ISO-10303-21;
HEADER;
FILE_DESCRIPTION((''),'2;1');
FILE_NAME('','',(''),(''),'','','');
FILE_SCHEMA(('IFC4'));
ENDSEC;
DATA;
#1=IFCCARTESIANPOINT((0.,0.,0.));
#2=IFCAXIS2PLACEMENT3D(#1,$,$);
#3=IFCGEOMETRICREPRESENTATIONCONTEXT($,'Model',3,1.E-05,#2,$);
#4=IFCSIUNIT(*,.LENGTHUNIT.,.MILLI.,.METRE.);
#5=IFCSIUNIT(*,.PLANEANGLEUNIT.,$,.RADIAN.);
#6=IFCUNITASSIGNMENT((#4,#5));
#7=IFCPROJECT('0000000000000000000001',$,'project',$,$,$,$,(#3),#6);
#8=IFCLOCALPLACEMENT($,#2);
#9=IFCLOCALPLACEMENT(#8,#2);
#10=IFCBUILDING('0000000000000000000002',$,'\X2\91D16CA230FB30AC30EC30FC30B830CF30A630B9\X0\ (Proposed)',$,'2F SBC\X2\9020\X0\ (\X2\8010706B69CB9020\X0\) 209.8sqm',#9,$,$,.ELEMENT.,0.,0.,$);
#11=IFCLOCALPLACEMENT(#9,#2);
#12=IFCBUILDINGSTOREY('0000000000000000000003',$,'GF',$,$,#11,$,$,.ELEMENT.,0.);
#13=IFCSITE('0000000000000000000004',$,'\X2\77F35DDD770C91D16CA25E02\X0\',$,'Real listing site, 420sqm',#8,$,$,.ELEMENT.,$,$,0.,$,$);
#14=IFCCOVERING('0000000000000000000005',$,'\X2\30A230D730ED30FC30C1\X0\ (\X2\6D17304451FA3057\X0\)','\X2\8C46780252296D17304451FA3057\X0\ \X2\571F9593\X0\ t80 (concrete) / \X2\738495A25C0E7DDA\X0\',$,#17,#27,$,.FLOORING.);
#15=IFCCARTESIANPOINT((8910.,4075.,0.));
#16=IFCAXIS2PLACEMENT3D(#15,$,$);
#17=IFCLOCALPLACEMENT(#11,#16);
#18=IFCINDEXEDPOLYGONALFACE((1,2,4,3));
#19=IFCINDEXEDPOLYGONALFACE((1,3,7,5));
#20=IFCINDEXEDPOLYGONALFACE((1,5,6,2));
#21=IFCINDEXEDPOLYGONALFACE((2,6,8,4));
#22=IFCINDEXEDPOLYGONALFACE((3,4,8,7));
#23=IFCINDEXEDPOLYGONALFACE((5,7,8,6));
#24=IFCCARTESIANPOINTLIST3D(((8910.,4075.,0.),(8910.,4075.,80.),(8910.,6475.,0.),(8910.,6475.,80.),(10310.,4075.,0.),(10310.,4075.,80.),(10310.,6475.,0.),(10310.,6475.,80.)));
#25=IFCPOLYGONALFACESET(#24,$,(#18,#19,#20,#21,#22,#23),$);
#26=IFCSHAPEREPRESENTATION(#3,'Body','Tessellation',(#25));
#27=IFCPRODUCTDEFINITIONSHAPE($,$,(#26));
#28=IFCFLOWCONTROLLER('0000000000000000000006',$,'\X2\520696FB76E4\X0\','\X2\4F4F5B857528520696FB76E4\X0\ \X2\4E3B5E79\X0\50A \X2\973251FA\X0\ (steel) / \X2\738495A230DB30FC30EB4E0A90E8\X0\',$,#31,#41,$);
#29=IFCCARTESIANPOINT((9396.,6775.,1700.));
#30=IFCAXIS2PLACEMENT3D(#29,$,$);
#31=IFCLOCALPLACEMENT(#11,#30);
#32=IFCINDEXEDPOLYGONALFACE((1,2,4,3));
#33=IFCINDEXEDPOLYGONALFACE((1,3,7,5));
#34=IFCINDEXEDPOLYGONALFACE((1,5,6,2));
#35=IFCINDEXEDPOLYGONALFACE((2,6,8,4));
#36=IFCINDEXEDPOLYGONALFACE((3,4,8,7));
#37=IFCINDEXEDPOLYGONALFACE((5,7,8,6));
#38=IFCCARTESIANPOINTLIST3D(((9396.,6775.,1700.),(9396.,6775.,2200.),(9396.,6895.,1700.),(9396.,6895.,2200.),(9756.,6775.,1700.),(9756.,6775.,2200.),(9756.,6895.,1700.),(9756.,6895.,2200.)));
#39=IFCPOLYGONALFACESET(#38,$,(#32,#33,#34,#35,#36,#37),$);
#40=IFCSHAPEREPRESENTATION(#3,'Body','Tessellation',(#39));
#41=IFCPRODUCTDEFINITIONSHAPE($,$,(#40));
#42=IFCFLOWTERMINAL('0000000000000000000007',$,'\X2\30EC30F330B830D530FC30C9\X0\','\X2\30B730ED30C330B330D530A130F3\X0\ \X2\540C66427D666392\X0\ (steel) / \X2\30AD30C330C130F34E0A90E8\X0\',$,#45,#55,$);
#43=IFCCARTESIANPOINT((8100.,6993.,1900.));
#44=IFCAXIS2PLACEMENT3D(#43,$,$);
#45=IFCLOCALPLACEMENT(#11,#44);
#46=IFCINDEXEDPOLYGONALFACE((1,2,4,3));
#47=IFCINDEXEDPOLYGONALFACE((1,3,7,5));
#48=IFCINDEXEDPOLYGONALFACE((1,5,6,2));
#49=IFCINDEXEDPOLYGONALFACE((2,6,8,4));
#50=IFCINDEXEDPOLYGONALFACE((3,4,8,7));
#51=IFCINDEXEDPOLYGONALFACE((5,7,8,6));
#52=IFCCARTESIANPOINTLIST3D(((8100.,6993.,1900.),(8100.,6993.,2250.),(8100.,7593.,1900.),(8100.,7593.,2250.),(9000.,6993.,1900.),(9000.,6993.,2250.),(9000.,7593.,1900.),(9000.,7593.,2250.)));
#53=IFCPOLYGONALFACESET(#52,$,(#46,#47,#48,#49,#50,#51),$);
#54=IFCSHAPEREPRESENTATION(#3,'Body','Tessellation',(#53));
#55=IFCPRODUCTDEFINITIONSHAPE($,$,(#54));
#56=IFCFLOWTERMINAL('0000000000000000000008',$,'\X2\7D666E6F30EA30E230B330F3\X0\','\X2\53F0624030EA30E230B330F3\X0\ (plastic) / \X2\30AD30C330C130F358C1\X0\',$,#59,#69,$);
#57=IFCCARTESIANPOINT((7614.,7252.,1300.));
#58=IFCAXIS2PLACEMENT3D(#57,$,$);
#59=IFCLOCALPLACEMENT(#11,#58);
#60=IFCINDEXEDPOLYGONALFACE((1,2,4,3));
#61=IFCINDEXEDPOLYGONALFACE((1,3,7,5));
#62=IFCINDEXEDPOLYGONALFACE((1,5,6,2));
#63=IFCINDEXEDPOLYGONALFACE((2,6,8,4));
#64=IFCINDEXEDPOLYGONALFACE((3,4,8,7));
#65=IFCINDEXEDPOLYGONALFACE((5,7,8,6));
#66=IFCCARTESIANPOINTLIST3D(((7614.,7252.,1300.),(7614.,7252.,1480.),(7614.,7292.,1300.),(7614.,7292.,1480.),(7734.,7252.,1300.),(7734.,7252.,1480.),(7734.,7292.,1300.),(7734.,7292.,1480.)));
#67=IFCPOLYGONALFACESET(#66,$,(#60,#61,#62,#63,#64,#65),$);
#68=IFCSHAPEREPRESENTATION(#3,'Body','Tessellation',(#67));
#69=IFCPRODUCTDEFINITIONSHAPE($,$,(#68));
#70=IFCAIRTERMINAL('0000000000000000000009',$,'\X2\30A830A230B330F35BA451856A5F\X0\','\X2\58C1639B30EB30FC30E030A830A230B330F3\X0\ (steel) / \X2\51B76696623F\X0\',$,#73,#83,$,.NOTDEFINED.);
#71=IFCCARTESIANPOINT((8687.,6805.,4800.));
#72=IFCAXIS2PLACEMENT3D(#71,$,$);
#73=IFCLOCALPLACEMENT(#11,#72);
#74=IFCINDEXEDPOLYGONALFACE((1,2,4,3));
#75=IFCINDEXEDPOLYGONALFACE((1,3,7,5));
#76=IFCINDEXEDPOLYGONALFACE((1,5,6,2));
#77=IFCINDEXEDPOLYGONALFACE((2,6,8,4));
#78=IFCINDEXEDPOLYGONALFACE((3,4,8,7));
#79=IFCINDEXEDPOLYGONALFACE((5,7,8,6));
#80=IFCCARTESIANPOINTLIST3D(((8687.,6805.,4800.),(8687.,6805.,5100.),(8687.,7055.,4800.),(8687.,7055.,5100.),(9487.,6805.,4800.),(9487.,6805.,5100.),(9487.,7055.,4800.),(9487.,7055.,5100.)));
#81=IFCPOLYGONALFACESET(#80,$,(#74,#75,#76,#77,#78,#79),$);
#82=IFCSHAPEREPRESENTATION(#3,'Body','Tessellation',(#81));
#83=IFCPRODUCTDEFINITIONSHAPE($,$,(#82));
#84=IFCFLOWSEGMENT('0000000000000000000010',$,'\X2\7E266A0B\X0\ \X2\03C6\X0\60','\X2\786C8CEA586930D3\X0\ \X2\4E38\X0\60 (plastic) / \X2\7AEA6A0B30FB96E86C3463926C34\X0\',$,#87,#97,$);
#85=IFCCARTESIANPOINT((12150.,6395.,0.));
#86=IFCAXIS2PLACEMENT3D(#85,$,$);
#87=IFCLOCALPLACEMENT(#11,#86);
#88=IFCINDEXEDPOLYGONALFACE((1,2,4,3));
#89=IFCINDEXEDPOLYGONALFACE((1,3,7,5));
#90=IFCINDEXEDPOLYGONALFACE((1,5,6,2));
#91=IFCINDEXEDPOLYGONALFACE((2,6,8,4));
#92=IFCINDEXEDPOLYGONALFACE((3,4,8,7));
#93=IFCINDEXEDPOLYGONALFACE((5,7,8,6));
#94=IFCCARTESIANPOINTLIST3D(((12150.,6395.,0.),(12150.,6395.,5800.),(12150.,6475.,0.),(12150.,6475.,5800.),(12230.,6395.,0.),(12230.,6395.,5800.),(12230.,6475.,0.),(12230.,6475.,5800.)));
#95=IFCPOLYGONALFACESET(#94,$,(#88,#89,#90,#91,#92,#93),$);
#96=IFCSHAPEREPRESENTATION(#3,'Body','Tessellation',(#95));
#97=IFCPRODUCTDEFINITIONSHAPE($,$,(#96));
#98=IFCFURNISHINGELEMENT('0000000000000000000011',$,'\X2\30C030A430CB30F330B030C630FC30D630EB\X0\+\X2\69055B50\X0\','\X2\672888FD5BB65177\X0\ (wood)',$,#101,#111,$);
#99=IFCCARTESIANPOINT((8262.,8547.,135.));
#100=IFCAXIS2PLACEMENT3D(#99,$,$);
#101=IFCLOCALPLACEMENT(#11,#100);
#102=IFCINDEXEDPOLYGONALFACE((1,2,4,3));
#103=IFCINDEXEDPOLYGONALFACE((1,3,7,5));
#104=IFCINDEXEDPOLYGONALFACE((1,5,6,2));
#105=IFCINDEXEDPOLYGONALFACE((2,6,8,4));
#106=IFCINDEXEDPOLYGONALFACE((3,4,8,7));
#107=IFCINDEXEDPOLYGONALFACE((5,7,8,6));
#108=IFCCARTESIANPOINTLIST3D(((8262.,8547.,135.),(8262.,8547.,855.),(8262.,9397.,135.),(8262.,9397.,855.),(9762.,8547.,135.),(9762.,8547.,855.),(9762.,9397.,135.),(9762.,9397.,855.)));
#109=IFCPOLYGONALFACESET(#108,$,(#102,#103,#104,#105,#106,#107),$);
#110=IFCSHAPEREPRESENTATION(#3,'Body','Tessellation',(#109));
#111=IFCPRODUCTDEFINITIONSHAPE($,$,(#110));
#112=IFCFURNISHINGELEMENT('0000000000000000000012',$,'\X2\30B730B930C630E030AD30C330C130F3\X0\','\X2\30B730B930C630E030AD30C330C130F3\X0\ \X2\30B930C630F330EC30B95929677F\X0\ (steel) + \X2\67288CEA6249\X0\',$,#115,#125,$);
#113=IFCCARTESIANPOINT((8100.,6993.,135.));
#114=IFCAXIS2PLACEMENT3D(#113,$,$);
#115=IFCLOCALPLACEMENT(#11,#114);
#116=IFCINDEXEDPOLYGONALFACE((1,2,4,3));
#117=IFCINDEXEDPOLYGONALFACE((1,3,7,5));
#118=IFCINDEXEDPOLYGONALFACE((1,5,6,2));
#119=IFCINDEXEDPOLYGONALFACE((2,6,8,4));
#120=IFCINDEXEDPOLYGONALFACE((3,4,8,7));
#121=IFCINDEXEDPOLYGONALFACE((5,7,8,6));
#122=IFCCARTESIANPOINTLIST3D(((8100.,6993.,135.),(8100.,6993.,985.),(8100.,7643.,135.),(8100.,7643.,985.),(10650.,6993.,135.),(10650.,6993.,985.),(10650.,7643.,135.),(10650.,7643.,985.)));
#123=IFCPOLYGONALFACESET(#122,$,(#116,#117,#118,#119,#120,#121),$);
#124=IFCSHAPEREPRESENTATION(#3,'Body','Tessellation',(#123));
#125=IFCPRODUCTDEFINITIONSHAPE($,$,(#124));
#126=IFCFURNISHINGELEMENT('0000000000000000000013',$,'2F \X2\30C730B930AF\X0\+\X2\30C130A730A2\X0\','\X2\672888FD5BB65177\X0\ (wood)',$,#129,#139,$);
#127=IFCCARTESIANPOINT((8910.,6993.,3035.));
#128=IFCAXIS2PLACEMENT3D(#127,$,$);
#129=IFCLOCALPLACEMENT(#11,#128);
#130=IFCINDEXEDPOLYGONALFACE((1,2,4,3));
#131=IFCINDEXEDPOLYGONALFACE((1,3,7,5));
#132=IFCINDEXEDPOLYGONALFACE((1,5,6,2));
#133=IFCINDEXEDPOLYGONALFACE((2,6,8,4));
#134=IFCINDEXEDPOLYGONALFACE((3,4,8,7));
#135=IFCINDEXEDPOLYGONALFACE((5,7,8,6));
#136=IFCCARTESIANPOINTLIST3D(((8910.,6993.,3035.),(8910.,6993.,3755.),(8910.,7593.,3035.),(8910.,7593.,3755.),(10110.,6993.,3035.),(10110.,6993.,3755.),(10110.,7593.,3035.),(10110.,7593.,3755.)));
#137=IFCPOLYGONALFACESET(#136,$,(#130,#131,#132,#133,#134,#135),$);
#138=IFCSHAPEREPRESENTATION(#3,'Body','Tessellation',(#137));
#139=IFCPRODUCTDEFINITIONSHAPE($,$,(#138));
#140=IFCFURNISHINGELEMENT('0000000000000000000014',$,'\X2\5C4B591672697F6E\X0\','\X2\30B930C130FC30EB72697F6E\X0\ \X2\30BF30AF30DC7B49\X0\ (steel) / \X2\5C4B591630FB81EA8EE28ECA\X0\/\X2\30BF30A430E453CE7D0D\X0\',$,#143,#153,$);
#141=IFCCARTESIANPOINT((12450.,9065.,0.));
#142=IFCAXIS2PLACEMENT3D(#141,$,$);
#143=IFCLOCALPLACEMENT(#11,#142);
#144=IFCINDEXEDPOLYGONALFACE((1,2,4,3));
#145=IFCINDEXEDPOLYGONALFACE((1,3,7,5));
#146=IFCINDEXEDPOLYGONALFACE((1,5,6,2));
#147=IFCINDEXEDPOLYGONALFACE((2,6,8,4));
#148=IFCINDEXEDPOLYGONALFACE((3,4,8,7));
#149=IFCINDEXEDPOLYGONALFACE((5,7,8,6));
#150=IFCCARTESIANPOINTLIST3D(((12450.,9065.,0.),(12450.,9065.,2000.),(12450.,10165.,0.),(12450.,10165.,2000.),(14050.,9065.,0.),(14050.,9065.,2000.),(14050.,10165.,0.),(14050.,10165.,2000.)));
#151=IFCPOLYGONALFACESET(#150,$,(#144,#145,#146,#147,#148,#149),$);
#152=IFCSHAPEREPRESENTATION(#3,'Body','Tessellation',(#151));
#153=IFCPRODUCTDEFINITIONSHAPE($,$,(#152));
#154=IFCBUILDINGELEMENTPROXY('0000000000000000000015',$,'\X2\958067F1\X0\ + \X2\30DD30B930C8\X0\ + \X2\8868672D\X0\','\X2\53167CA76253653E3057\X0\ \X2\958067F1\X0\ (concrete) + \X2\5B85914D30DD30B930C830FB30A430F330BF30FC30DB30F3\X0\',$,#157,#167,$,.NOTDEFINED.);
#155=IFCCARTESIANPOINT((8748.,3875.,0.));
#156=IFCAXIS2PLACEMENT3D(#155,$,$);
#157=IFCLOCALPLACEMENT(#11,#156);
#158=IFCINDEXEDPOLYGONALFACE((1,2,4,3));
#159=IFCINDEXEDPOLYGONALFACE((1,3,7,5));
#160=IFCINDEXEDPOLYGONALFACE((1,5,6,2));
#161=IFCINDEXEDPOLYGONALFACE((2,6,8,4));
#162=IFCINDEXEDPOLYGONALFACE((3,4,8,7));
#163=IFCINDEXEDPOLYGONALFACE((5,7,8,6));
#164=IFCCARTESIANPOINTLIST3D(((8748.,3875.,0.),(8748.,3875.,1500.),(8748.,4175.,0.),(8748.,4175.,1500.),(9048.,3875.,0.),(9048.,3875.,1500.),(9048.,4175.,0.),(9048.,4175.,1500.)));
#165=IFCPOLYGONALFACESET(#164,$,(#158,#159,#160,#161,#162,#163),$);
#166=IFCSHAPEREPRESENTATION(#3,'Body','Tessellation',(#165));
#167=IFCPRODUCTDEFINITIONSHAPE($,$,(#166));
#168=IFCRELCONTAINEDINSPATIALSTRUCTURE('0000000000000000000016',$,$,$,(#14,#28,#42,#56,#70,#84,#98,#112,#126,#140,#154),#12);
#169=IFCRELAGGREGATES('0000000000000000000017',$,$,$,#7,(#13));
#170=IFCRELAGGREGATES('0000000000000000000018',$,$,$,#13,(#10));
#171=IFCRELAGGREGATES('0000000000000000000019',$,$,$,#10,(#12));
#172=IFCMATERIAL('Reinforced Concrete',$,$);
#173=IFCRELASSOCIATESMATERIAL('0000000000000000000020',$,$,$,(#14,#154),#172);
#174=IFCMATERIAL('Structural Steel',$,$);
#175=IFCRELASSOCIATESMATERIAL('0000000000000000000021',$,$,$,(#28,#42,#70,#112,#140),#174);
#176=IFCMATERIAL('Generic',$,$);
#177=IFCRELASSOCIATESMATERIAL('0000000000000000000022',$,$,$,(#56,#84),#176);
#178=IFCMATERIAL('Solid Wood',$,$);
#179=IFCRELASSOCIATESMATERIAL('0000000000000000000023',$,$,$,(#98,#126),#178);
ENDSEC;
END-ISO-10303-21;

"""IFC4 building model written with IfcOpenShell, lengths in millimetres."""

from ifc_helpers import new_model, si_unit, frame, frame_2d, origin, place, context, project, spatial, rectangle, extrude, material, element, save


model = new_model("IFC4")

# Units and contexts
model_context = context("Model", 3, precision=1e-05, world=origin())
ifc_project = project(units=[si_unit("LENGTHUNIT", "METRE", prefix="MILLI"), si_unit("PLANEANGLEUNIT", "RADIAN")], contexts=[model_context])

# Site, building, storey
site_placement = place(None, origin())
site = spatial("IfcSite", under=ifc_project, at=site_placement, Name="石川県金沢市", ObjectType="Real listing site, 420sqm", CompositionType="ELEMENT", RefElevation=0.0)
building_placement = place(site_placement, origin())
building = spatial("IfcBuilding", under=site, at=building_placement, Name="金沢・ガレージハウス (Proposed)", ObjectType="2F SBC造 (耐火構造) 209.8sqm", CompositionType="ELEMENT", ElevationOfRefHeight=0.0, ElevationOfTerrain=0.0)
storey_placement = place(building_placement, origin())
storey = spatial("IfcBuildingStorey", under=building, at=storey_placement, Name="GF", CompositionType="ELEMENT", Elevation=0.0)

# Shared definitions
ifc_material_1 = material(Name="Solid Wood")
ifc_material_2 = material(Name="Structural Steel")

# Shared definitions
ifc_material_3 = material(Name="Reinforced Concrete")

# Covering
covering_placement = place(storey_placement, frame((8910.0, 4075.0, 0.0)))
element("IfcCovering", 1, at=covering_placement, inside=storey, material=ifc_material_3, Name="アプローチ (洗い出し)", Description="豆砂利洗い出し 土間 t80 (concrete) / 玄関導線", PredefinedType="FLOORING", context=model_context, shape_type="SweptSolid", body=[
    extrude(rectangle(XDim=1400.0, YDim=2400.0, at=frame_2d((700.0, 1200.0))), frame((8910.0, 4075.0, 0.0)), (0.0, 0.0, 1.0), 80.0),
])

# Flow controller
flow_controller_placement = place(storey_placement, frame((9396.0, 6775.0, 1700.0)))
element("IfcFlowController", 2, at=flow_controller_placement, inside=storey, material=ifc_material_2, Name="分電盤", Description="住宅用分電盤 主幹50A 露出 (steel) / 玄関ホール上部", context=model_context, shape_type="SweptSolid", body=[
    extrude(rectangle(XDim=360.0, YDim=120.0, at=frame_2d((180.0, 60.0))), frame((9396.0, 6775.0, 1700.0)), (0.0, 0.0, 1.0), 500.0),
])

# Flow terminals
flow_terminal_1_placement = place(storey_placement, frame((8100.0, 6993.0, 1900.0)))
element("IfcFlowTerminal", 3, at=flow_terminal_1_placement, inside=storey, material=ifc_material_2, Name="レンジフード", Description="シロッコファン 同時給排 (steel) / キッチン上部", context=model_context, shape_type="SweptSolid", body=[
    extrude(rectangle(XDim=900.0, YDim=600.0, at=frame_2d((450.0, 300.0))), frame((8100.0, 6993.0, 1900.0)), (0.0, 0.0, 1.0), 350.0),
])
ifc_material_4 = material(Name="Generic")
flow_terminal_2_placement = place(storey_placement, frame((7614.0, 7252.0, 1300.0)))
element("IfcFlowTerminal", 4, at=flow_terminal_2_placement, inside=storey, material=ifc_material_4, Name="給湯リモコン", Description="台所リモコン (plastic) / キッチン壁", context=model_context, shape_type="SweptSolid", body=[
    extrude(rectangle(XDim=120.0, YDim=40.0, at=frame_2d((60.0, 20.0))), frame((7614.0, 7252.0, 1300.0)), (0.0, 0.0, 1.0), 180.0),
])

# Air terminal
air_terminal_placement = place(storey_placement, frame((8687.0, 6805.0, 4800.0)))
element("IfcAirTerminal", 5, at=air_terminal_placement, inside=storey, material=ifc_material_2, Name="エアコン室内機", Description="壁掛ルームエアコン (steel) / 冷暖房", PredefinedType="NOTDEFINED", context=model_context, shape_type="SweptSolid", body=[
    extrude(rectangle(XDim=800.0, YDim=250.0, at=frame_2d((400.0, 125.0))), frame((8687.0, 6805.0, 4800.0)), (0.0, 0.0, 1.0), 300.0),
])

# Flow segment
flow_segment_placement = place(storey_placement, frame((12150.0, 6395.0, 0.0)))
element("IfcFlowSegment", 6, at=flow_segment_placement, inside=storey, material=ifc_material_4, Name="縦樋 φ60", Description="硬質塩ビ 丸60 (plastic) / 竪樋・雨水排水", context=model_context, shape_type="SweptSolid", body=[
    extrude(rectangle(XDim=80.0, YDim=80.0, at=frame_2d((40.0, 40.0))), frame((12150.0, 6395.0, 0.0)), (0.0, 0.0, 1.0), 5800.0),
])

# Furnishing elements
furnishing_1_placement = place(storey_placement, frame((8262.0, 8547.0, 135.0)))
element("IfcFurnishingElement", 7, at=furnishing_1_placement, inside=storey, material=ifc_material_1, Name="ダイニングテーブル+椅子", Description="木製家具 (wood)", context=model_context, shape_type="SweptSolid", body=[
    extrude(rectangle(XDim=1500.0, YDim=850.0, at=frame_2d((750.0, 425.0))), frame((8262.0, 8547.0, 135.0)), (0.0, 0.0, 1.0), 720.0),
])
furnishing_2_placement = place(storey_placement, frame((8100.0, 6993.0, 135.0)))
element("IfcFurnishingElement", 8, at=furnishing_2_placement, inside=storey, material=ifc_material_2, Name="システムキッチン", Description="システムキッチン ステンレス天板 (steel) + 木質扉", context=model_context, shape_type="SweptSolid", body=[
    extrude(rectangle(XDim=2550.0, YDim=650.0, at=frame_2d((1275.0, 325.0))), frame((8100.0, 6993.0, 135.0)), (0.0, 0.0, 1.0), 850.0),
])
furnishing_3_placement = place(storey_placement, frame((8910.0, 6993.0, 3035.0)))
element("IfcFurnishingElement", 9, at=furnishing_3_placement, inside=storey, material=ifc_material_1, Name="2F デスク+チェア", Description="木製家具 (wood)", context=model_context, shape_type="SweptSolid", body=[
    extrude(rectangle(XDim=1200.0, YDim=600.0, at=frame_2d((600.0, 300.0))), frame((8910.0, 6993.0, 3035.0)), (0.0, 0.0, 1.0), 720.0),
])
furnishing_4_placement = place(storey_placement, frame((12450.0, 9065.0, 0.0)))
element("IfcFurnishingElement", 10, at=furnishing_4_placement, inside=storey, material=ifc_material_2, Name="屋外物置", Description="スチール物置 タクボ等 (steel) / 屋外・自転車/タイヤ収納", context=model_context, shape_type="SweptSolid", body=[
    extrude(rectangle(XDim=1600.0, YDim=1100.0, at=frame_2d((800.0, 550.0))), frame((12450.0, 9065.0, 0.0)), (0.0, 0.0, 1.0), 2000.0),
])

# Building element proxy
proxy_placement = place(storey_placement, frame((8748.0, 3875.0, 0.0)))
element("IfcBuildingElementProxy", 11, at=proxy_placement, inside=storey, material=ifc_material_3, Name="門柱 + ポスト + 表札", Description="化粧打放し 門柱 (concrete) + 宅配ポスト・インターホン", PredefinedType="NOTDEFINED", context=model_context, shape_type="SweptSolid", body=[
    extrude(rectangle(XDim=300.0, YDim=300.0, at=frame_2d((150.0, 150.0))), frame((8748.0, 3875.0, 0.0)), (0.0, 0.0, 1.0), 1500.0),
])

save(model, "model.ifc")
